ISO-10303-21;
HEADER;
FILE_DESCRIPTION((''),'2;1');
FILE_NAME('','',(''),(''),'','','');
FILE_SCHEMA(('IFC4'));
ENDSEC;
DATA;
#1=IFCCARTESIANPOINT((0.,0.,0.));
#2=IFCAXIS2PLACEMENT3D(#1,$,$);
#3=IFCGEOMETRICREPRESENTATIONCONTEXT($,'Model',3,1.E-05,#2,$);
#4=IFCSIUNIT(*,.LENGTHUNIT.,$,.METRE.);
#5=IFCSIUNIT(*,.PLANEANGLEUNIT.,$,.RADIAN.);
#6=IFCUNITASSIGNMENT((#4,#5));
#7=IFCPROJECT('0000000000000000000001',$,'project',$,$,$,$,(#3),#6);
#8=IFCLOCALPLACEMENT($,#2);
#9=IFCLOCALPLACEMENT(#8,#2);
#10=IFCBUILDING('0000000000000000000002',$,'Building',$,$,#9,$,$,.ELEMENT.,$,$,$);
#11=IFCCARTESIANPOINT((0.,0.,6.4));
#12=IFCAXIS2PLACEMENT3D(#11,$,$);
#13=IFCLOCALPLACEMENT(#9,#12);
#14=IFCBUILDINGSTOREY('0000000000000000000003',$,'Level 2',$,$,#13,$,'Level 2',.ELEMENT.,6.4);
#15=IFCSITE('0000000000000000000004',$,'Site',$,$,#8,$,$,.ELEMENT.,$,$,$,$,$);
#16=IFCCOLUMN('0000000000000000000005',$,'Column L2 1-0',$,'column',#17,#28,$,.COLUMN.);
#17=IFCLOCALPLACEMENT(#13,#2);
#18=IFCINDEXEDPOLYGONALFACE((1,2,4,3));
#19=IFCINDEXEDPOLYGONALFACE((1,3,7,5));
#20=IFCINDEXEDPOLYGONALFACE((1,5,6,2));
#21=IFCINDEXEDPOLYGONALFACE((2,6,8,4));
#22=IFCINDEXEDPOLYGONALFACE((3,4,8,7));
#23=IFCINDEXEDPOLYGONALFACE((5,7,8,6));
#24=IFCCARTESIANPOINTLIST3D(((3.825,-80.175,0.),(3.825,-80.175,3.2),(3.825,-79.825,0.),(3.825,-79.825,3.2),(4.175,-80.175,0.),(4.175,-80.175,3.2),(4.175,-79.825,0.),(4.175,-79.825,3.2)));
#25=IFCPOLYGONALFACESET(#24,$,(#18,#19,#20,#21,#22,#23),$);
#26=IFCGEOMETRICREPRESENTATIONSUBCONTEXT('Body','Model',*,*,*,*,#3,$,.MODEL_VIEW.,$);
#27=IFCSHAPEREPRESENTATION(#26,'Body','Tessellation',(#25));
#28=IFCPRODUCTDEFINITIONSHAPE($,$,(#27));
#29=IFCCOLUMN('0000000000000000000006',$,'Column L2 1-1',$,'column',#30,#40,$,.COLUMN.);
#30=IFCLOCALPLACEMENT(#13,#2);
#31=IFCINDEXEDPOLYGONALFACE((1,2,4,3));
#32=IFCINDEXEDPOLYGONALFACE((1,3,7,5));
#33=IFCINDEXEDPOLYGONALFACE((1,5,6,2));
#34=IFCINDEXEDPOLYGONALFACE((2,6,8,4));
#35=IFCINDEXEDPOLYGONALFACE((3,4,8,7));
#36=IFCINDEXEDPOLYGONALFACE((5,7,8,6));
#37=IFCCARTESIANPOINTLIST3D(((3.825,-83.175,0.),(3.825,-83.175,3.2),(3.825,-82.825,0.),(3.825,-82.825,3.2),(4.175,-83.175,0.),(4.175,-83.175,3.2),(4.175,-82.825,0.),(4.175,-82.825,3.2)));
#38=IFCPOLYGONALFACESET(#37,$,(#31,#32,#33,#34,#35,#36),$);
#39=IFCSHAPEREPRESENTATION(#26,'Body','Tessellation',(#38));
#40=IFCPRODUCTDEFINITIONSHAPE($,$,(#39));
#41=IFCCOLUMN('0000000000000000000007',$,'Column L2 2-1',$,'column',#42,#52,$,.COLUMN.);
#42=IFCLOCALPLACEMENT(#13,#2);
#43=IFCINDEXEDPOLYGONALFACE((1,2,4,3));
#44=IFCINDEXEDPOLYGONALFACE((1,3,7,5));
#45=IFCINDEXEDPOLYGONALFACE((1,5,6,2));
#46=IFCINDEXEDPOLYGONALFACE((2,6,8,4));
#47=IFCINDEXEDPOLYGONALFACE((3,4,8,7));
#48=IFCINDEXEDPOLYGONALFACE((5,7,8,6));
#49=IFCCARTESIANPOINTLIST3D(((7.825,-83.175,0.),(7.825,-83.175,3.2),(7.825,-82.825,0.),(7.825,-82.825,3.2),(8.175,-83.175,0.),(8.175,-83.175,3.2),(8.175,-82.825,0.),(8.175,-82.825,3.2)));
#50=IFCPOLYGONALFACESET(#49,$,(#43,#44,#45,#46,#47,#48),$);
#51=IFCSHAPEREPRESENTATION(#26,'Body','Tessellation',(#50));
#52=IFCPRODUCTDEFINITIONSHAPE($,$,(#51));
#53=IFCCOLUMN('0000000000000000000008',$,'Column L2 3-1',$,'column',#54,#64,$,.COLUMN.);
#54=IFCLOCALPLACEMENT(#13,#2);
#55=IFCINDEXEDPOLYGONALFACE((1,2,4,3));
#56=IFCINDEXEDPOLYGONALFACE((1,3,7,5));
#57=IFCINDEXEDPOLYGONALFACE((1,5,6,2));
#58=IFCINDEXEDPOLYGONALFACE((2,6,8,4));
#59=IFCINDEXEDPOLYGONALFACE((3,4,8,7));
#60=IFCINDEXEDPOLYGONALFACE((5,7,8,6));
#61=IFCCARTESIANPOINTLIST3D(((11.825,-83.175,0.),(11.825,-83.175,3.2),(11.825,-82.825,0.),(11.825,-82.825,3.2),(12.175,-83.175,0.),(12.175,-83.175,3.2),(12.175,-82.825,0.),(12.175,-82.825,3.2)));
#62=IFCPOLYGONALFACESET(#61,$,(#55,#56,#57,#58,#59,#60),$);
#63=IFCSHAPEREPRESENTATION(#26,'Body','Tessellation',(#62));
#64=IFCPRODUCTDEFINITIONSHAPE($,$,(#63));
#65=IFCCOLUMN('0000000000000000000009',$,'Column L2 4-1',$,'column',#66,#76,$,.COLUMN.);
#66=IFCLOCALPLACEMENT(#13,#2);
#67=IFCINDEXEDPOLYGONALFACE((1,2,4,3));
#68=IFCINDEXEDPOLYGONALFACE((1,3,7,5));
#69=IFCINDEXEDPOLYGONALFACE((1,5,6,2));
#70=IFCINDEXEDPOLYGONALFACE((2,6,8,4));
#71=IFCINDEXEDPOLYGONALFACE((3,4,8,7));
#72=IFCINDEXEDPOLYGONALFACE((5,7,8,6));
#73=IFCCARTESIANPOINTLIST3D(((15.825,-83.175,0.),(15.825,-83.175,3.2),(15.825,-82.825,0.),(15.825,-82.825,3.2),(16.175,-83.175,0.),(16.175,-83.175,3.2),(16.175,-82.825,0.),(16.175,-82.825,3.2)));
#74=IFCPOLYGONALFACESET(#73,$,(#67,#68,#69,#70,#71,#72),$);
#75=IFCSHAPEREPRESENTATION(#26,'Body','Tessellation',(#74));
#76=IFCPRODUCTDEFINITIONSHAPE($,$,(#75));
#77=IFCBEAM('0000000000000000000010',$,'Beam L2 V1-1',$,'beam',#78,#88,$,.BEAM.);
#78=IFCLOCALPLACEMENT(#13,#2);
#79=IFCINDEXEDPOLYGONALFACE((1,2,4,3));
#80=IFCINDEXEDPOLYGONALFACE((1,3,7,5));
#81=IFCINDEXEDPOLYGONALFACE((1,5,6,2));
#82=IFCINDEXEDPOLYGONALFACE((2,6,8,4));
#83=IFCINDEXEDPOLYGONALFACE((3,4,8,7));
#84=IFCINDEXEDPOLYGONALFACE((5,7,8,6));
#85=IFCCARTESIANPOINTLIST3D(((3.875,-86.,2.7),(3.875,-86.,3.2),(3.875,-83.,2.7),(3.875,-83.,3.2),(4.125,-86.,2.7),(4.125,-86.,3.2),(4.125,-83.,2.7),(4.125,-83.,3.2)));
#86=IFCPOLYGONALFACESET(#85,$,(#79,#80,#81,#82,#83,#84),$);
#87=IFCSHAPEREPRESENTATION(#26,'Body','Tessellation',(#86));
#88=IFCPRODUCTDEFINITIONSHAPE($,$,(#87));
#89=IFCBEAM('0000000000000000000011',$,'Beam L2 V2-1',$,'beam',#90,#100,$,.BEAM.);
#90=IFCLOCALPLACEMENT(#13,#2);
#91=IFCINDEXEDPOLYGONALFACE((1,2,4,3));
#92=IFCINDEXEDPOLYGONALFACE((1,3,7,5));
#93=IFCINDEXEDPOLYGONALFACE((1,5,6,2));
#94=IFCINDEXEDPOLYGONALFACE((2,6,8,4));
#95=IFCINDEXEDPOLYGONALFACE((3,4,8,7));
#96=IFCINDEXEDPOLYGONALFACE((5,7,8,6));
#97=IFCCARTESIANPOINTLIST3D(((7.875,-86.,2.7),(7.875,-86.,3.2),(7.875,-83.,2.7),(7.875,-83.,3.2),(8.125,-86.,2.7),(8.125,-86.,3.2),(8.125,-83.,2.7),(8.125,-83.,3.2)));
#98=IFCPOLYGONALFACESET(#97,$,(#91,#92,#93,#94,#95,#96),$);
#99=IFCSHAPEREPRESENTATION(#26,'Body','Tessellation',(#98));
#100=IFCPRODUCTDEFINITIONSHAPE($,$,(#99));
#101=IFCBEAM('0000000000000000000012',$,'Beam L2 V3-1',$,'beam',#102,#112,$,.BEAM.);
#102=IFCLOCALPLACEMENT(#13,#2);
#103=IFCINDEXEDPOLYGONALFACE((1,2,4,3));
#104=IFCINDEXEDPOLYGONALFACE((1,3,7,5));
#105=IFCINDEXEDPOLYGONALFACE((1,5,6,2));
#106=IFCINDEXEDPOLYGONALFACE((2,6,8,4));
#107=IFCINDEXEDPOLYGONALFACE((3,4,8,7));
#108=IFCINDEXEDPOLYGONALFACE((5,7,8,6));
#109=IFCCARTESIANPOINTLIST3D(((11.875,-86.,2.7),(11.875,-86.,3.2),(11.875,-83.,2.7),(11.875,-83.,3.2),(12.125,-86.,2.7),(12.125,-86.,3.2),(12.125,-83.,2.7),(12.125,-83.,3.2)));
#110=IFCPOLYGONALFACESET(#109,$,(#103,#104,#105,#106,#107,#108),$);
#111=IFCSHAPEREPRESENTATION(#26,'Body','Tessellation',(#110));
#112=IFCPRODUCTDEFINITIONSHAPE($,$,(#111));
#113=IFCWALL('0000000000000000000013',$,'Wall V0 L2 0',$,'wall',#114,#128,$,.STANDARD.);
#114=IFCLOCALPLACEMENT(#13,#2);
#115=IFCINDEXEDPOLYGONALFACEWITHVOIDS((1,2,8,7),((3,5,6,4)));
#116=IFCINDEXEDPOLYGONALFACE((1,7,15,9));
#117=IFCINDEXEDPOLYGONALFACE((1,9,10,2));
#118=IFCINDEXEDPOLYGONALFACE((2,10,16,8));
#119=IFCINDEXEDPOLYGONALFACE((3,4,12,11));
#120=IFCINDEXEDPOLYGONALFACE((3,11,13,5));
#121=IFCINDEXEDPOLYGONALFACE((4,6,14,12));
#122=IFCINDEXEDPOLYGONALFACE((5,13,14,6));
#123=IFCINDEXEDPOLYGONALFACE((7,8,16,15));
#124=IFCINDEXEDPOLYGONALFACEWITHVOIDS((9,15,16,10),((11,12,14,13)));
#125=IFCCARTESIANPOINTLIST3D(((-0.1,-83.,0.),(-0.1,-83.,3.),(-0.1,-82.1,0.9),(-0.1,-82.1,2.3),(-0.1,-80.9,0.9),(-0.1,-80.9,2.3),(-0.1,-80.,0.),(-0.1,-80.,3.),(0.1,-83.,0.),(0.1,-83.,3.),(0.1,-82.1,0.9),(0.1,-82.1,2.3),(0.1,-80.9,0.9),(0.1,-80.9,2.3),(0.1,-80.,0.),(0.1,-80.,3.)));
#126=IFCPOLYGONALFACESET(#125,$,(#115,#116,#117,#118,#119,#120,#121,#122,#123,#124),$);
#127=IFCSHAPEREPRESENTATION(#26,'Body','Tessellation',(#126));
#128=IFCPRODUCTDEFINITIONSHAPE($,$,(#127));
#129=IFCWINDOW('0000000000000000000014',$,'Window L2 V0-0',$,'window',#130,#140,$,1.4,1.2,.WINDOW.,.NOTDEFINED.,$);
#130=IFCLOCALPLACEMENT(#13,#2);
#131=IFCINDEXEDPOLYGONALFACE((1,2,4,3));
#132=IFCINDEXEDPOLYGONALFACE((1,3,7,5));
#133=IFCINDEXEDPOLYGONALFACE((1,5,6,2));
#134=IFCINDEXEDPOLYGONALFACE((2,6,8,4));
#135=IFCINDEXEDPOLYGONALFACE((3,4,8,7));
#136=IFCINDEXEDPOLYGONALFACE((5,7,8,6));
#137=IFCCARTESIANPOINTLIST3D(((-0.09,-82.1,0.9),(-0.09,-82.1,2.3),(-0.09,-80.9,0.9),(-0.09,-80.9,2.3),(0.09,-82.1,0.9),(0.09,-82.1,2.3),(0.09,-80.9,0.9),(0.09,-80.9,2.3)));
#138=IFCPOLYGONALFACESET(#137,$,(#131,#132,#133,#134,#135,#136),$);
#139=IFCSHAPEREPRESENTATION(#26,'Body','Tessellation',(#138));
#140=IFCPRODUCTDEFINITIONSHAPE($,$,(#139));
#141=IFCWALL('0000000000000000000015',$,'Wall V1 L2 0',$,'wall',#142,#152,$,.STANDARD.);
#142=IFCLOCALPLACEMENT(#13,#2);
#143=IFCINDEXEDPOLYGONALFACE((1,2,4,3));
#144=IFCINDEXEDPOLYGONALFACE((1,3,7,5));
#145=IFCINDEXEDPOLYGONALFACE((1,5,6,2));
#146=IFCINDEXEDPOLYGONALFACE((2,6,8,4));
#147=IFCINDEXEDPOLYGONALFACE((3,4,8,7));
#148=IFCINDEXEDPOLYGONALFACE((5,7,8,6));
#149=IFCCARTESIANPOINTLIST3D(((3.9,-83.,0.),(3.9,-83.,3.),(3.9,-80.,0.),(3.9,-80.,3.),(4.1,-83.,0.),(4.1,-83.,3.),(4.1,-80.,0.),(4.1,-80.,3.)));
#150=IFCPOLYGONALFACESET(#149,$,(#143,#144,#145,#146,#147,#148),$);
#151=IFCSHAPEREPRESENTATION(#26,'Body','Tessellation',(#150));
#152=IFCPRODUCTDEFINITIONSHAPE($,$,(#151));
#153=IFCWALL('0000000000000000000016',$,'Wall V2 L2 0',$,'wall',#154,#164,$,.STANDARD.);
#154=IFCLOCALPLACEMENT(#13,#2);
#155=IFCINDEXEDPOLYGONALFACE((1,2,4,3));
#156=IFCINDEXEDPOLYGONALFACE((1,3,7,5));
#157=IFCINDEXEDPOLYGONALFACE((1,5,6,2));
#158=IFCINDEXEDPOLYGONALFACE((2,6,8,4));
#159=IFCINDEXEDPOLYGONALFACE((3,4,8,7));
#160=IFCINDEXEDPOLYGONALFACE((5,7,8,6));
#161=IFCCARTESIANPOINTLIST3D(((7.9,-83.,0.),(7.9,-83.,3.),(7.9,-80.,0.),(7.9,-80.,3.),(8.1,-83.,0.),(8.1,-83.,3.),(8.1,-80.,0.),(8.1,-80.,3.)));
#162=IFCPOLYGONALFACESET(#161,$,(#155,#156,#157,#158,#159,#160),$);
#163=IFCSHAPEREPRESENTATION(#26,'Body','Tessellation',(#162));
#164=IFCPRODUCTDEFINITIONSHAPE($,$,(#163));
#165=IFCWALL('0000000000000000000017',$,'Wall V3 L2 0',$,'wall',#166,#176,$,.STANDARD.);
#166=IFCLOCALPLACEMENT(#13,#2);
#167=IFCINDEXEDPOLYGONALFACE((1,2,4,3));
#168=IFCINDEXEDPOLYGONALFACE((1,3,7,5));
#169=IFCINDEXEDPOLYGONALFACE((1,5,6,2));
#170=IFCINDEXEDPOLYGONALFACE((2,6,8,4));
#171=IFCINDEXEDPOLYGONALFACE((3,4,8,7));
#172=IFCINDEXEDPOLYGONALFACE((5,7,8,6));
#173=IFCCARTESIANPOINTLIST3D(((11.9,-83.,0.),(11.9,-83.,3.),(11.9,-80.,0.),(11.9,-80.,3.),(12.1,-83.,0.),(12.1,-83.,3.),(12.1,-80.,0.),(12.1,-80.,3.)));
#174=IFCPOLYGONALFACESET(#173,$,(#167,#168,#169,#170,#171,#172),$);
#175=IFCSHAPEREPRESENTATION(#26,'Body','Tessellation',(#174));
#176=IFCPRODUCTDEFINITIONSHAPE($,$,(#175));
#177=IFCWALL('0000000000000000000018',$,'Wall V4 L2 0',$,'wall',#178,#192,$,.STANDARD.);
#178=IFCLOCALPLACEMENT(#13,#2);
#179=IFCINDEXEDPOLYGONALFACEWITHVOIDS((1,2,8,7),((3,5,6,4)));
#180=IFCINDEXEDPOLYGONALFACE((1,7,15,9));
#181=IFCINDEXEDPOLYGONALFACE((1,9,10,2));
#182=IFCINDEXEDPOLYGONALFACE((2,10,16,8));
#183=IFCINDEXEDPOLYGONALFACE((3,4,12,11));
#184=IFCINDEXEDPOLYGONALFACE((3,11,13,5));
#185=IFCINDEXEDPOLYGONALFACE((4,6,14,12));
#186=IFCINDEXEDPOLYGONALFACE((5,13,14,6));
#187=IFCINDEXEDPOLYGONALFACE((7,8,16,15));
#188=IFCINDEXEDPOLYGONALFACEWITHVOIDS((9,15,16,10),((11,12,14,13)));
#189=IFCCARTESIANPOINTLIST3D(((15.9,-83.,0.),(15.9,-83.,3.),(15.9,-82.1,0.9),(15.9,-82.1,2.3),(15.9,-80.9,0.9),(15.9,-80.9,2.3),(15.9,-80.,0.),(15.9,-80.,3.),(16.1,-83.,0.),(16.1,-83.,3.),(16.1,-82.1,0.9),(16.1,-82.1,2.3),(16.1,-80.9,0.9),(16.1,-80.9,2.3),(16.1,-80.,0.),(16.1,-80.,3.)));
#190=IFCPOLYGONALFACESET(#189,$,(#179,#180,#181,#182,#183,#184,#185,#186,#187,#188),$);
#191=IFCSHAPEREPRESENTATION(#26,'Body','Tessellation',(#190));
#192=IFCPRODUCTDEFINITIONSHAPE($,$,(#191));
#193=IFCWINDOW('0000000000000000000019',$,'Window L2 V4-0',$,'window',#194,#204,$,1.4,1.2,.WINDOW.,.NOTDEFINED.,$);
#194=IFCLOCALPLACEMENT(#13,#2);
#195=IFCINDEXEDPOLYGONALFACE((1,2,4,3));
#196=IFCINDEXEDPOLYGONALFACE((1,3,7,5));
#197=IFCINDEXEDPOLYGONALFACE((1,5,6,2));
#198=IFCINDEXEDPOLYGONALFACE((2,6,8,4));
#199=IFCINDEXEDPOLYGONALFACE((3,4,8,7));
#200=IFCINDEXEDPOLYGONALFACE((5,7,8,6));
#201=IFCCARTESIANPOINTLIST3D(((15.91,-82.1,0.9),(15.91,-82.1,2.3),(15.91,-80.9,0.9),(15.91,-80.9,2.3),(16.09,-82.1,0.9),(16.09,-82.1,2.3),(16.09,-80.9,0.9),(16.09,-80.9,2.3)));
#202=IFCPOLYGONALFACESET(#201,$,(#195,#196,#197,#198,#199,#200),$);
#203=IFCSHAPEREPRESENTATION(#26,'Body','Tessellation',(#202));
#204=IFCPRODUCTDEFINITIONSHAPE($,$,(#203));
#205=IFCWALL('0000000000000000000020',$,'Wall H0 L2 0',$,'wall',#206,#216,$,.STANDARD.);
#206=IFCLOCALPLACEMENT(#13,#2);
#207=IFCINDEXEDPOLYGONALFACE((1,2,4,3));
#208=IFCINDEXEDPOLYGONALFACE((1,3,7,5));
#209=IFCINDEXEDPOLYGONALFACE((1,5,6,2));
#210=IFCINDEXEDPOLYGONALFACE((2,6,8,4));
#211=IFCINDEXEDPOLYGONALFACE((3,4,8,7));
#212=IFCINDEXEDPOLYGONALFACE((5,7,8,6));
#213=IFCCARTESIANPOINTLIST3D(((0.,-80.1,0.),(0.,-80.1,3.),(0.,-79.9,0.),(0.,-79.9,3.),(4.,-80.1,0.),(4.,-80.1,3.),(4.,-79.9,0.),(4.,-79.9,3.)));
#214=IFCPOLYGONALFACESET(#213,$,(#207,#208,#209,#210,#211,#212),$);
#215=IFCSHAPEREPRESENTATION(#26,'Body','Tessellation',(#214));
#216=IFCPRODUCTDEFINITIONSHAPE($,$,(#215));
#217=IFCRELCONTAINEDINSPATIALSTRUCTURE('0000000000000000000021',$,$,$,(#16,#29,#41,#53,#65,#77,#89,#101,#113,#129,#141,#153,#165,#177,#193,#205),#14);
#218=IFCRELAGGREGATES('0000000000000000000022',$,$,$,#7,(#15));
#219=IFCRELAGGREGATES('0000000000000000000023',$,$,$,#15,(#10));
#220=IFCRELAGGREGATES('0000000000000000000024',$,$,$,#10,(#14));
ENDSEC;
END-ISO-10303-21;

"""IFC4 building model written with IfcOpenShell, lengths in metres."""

from ifc_helpers import new_model, si_unit, frame, frame_2d, origin, origin_2d, place, context, subcontext, project, spatial, rectangle, extrude, element, fill, save


model = new_model("IFC4")

# Units and contexts
model_context = context("Model", 3, precision=1e-05, world=origin())
body_context = subcontext(model_context, "Body", "Model", "MODEL_VIEW")
ifc_project = project(units=[si_unit("LENGTHUNIT", "METRE"), si_unit("PLANEANGLEUNIT", "RADIAN")], contexts=[model_context])

# Site, building, storey
site_placement = place(None, origin())
site = spatial("IfcSite", under=ifc_project, at=site_placement, Name="Site", CompositionType="ELEMENT")
building_placement = place(site_placement, origin())
building = spatial("IfcBuilding", under=site, at=building_placement, Name="Building", CompositionType="ELEMENT")
storey_placement = place(building_placement, frame((0.0, 0.0, 6.4)))
storey = spatial("IfcBuildingStorey", under=building, at=storey_placement, Name="Level 2", LongName="Level 2", CompositionType="ELEMENT", Elevation=6.4)

# Columns
for number, where, name in (
    (1, (4.0, -80.0, 0.0), "Column L2 1-0"),
    (2, (4.0, -83.0, 0.0), "Column L2 1-1"),
    (3, (8.0, -83.0, 0.0), "Column L2 2-1"),
    (4, (12.0, -83.0, 0.0), "Column L2 3-1"),
    (5, (16.0, -83.0, 0.0), "Column L2 4-1"),
):
    element("IfcColumn", number, at=place(storey_placement, frame(where)), inside=storey, Name=name, ObjectType="column", PredefinedType="COLUMN", context=body_context, shape_type="SweptSolid", body=[
        extrude(rectangle(XDim=0.35, YDim=0.35, at=origin_2d()), origin(), (0.0, 0.0, 1.0), 3.2),
    ])

# Beams
for number, where, z_axis, x_axis, name in (
    (6, (4.0, -83.0, 2.95), (0.0, -1.0, 0.0), (0.0, 0.0, 1.0), "Beam L2 V1-1"),
    (7, (8.0, -83.0, 2.95), (0.0, -1.0, 0.0), (0.0, 0.0, 1.0), "Beam L2 V2-1"),
    (8, (12.0, -83.0, 2.95), (0.0, -1.0, 0.0), (0.0, 0.0, 1.0), "Beam L2 V3-1"),
):
    element("IfcBeam", number, at=place(storey_placement, frame(where, z_axis=z_axis, x_axis=x_axis)), inside=storey, Name=name, ObjectType="beam", PredefinedType="BEAM", context=body_context, shape_type="SweptSolid", body=[
        extrude(rectangle(XDim=0.5, YDim=0.25, at=origin_2d()), origin(), (0.0, 0.0, 1.0), 3.0),
    ])

# Wall, opening, window
wall_1_placement = place(storey_placement, frame((0.0, -80.0, 0.0), z_axis=(0.0, 0.0, 1.0), x_axis=(0.0, -1.0, 0.0)))
wall_1 = element("IfcWall", 9, at=wall_1_placement, inside=storey, Name="Wall V0 L2 0", ObjectType="wall", PredefinedType="STANDARD", context=body_context, shape_type="SweptSolid", body=[
    extrude(rectangle(XDim=3.0, YDim=0.2, at=frame_2d((1.5, 0.0))), origin(), (0.0, 0.0, 1.0), 3.0),
])
opening_1_placement = place(storey_placement, frame((0.0, -81.5, 0.9), z_axis=(0.0, 0.0, 1.0), x_axis=(0.0, -1.0, 0.0)))
opening_1 = element("IfcOpeningElement", 10, at=opening_1_placement, cuts=wall_1, ObjectType="Opening", PredefinedType="OPENING", context=body_context, shape_type="SweptSolid", body=[
    extrude(rectangle(XDim=1.2, YDim=0.22, at=origin_2d()), origin(), (0.0, 0.0, 1.0), 1.4),
])
window_1_placement = place(storey_placement, frame((0.0, -81.5, 0.9), z_axis=(0.0, 0.0, 1.0), x_axis=(0.0, -1.0, 0.0)))
window_1 = element("IfcWindow", 11, at=window_1_placement, inside=storey, Name="Window L2 V0-0", ObjectType="window", OverallHeight=1.4, OverallWidth=1.2, PartitioningType="NOTDEFINED", PredefinedType="WINDOW", context=body_context, shape_type="SweptSolid", body=[
    extrude(rectangle(XDim=1.2, YDim=0.18, at=origin_2d()), origin(), (0.0, 0.0, 1.0), 1.4),
])
fill(opening_1, window_1)

# Walls
for number, where, z_axis, x_axis, name in (
    (12, (4.0, -80.0, 0.0), (0.0, 0.0, 1.0), (0.0, -1.0, 0.0), "Wall V1 L2 0"),
    (13, (8.0, -80.0, 0.0), (0.0, 0.0, 1.0), (0.0, -1.0, 0.0), "Wall V2 L2 0"),
    (14, (12.0, -80.0, 0.0), (0.0, 0.0, 1.0), (0.0, -1.0, 0.0), "Wall V3 L2 0"),
):
    element("IfcWall", number, at=place(storey_placement, frame(where, z_axis=z_axis, x_axis=x_axis)), inside=storey, Name=name, ObjectType="wall", PredefinedType="STANDARD", context=body_context, shape_type="SweptSolid", body=[
        extrude(rectangle(XDim=3.0, YDim=0.2, at=frame_2d((1.5, 0.0))), origin(), (0.0, 0.0, 1.0), 3.0),
    ])

# Wall, opening, window
wall_2_placement = place(storey_placement, frame((16.0, -80.0, 0.0), z_axis=(0.0, 0.0, 1.0), x_axis=(0.0, -1.0, 0.0)))
wall_2 = element("IfcWall", 15, at=wall_2_placement, inside=storey, Name="Wall V4 L2 0", ObjectType="wall", PredefinedType="STANDARD", context=body_context, shape_type="SweptSolid", body=[
    extrude(rectangle(XDim=3.0, YDim=0.2, at=frame_2d((1.5, 0.0))), origin(), (0.0, 0.0, 1.0), 3.0),
])
opening_2_placement = place(storey_placement, frame((16.0, -81.5, 0.9), z_axis=(0.0, 0.0, 1.0), x_axis=(0.0, -1.0, 0.0)))
opening_2 = element("IfcOpeningElement", 16, at=opening_2_placement, cuts=wall_2, ObjectType="Opening", PredefinedType="OPENING", context=body_context, shape_type="SweptSolid", body=[
    extrude(rectangle(XDim=1.2, YDim=0.22, at=origin_2d()), origin(), (0.0, 0.0, 1.0), 1.4),
])
window_2_placement = place(storey_placement, frame((16.0, -81.5, 0.9), z_axis=(0.0, 0.0, 1.0), x_axis=(0.0, -1.0, 0.0)))
window_2 = element("IfcWindow", 17, at=window_2_placement, inside=storey, Name="Window L2 V4-0", ObjectType="window", OverallHeight=1.4, OverallWidth=1.2, PartitioningType="NOTDEFINED", PredefinedType="WINDOW", context=body_context, shape_type="SweptSolid", body=[
    extrude(rectangle(XDim=1.2, YDim=0.18, at=origin_2d()), origin(), (0.0, 0.0, 1.0), 1.4),
])
fill(opening_2, window_2)

# Wall
wall_3_placement = place(storey_placement, frame((0.0, -80.0, 0.0), z_axis=(0.0, 0.0, 1.0), x_axis=(1.0, 0.0, 0.0)))
element("IfcWall", 18, at=wall_3_placement, inside=storey, Name="Wall H0 L2 0", ObjectType="wall", PredefinedType="STANDARD", context=body_context, shape_type="SweptSolid", body=[
    extrude(rectangle(XDim=4.0, YDim=0.2, at=frame_2d((2.0, 0.0))), origin(), (0.0, 0.0, 1.0), 3.0),
])

save(model, "model.ifc")
